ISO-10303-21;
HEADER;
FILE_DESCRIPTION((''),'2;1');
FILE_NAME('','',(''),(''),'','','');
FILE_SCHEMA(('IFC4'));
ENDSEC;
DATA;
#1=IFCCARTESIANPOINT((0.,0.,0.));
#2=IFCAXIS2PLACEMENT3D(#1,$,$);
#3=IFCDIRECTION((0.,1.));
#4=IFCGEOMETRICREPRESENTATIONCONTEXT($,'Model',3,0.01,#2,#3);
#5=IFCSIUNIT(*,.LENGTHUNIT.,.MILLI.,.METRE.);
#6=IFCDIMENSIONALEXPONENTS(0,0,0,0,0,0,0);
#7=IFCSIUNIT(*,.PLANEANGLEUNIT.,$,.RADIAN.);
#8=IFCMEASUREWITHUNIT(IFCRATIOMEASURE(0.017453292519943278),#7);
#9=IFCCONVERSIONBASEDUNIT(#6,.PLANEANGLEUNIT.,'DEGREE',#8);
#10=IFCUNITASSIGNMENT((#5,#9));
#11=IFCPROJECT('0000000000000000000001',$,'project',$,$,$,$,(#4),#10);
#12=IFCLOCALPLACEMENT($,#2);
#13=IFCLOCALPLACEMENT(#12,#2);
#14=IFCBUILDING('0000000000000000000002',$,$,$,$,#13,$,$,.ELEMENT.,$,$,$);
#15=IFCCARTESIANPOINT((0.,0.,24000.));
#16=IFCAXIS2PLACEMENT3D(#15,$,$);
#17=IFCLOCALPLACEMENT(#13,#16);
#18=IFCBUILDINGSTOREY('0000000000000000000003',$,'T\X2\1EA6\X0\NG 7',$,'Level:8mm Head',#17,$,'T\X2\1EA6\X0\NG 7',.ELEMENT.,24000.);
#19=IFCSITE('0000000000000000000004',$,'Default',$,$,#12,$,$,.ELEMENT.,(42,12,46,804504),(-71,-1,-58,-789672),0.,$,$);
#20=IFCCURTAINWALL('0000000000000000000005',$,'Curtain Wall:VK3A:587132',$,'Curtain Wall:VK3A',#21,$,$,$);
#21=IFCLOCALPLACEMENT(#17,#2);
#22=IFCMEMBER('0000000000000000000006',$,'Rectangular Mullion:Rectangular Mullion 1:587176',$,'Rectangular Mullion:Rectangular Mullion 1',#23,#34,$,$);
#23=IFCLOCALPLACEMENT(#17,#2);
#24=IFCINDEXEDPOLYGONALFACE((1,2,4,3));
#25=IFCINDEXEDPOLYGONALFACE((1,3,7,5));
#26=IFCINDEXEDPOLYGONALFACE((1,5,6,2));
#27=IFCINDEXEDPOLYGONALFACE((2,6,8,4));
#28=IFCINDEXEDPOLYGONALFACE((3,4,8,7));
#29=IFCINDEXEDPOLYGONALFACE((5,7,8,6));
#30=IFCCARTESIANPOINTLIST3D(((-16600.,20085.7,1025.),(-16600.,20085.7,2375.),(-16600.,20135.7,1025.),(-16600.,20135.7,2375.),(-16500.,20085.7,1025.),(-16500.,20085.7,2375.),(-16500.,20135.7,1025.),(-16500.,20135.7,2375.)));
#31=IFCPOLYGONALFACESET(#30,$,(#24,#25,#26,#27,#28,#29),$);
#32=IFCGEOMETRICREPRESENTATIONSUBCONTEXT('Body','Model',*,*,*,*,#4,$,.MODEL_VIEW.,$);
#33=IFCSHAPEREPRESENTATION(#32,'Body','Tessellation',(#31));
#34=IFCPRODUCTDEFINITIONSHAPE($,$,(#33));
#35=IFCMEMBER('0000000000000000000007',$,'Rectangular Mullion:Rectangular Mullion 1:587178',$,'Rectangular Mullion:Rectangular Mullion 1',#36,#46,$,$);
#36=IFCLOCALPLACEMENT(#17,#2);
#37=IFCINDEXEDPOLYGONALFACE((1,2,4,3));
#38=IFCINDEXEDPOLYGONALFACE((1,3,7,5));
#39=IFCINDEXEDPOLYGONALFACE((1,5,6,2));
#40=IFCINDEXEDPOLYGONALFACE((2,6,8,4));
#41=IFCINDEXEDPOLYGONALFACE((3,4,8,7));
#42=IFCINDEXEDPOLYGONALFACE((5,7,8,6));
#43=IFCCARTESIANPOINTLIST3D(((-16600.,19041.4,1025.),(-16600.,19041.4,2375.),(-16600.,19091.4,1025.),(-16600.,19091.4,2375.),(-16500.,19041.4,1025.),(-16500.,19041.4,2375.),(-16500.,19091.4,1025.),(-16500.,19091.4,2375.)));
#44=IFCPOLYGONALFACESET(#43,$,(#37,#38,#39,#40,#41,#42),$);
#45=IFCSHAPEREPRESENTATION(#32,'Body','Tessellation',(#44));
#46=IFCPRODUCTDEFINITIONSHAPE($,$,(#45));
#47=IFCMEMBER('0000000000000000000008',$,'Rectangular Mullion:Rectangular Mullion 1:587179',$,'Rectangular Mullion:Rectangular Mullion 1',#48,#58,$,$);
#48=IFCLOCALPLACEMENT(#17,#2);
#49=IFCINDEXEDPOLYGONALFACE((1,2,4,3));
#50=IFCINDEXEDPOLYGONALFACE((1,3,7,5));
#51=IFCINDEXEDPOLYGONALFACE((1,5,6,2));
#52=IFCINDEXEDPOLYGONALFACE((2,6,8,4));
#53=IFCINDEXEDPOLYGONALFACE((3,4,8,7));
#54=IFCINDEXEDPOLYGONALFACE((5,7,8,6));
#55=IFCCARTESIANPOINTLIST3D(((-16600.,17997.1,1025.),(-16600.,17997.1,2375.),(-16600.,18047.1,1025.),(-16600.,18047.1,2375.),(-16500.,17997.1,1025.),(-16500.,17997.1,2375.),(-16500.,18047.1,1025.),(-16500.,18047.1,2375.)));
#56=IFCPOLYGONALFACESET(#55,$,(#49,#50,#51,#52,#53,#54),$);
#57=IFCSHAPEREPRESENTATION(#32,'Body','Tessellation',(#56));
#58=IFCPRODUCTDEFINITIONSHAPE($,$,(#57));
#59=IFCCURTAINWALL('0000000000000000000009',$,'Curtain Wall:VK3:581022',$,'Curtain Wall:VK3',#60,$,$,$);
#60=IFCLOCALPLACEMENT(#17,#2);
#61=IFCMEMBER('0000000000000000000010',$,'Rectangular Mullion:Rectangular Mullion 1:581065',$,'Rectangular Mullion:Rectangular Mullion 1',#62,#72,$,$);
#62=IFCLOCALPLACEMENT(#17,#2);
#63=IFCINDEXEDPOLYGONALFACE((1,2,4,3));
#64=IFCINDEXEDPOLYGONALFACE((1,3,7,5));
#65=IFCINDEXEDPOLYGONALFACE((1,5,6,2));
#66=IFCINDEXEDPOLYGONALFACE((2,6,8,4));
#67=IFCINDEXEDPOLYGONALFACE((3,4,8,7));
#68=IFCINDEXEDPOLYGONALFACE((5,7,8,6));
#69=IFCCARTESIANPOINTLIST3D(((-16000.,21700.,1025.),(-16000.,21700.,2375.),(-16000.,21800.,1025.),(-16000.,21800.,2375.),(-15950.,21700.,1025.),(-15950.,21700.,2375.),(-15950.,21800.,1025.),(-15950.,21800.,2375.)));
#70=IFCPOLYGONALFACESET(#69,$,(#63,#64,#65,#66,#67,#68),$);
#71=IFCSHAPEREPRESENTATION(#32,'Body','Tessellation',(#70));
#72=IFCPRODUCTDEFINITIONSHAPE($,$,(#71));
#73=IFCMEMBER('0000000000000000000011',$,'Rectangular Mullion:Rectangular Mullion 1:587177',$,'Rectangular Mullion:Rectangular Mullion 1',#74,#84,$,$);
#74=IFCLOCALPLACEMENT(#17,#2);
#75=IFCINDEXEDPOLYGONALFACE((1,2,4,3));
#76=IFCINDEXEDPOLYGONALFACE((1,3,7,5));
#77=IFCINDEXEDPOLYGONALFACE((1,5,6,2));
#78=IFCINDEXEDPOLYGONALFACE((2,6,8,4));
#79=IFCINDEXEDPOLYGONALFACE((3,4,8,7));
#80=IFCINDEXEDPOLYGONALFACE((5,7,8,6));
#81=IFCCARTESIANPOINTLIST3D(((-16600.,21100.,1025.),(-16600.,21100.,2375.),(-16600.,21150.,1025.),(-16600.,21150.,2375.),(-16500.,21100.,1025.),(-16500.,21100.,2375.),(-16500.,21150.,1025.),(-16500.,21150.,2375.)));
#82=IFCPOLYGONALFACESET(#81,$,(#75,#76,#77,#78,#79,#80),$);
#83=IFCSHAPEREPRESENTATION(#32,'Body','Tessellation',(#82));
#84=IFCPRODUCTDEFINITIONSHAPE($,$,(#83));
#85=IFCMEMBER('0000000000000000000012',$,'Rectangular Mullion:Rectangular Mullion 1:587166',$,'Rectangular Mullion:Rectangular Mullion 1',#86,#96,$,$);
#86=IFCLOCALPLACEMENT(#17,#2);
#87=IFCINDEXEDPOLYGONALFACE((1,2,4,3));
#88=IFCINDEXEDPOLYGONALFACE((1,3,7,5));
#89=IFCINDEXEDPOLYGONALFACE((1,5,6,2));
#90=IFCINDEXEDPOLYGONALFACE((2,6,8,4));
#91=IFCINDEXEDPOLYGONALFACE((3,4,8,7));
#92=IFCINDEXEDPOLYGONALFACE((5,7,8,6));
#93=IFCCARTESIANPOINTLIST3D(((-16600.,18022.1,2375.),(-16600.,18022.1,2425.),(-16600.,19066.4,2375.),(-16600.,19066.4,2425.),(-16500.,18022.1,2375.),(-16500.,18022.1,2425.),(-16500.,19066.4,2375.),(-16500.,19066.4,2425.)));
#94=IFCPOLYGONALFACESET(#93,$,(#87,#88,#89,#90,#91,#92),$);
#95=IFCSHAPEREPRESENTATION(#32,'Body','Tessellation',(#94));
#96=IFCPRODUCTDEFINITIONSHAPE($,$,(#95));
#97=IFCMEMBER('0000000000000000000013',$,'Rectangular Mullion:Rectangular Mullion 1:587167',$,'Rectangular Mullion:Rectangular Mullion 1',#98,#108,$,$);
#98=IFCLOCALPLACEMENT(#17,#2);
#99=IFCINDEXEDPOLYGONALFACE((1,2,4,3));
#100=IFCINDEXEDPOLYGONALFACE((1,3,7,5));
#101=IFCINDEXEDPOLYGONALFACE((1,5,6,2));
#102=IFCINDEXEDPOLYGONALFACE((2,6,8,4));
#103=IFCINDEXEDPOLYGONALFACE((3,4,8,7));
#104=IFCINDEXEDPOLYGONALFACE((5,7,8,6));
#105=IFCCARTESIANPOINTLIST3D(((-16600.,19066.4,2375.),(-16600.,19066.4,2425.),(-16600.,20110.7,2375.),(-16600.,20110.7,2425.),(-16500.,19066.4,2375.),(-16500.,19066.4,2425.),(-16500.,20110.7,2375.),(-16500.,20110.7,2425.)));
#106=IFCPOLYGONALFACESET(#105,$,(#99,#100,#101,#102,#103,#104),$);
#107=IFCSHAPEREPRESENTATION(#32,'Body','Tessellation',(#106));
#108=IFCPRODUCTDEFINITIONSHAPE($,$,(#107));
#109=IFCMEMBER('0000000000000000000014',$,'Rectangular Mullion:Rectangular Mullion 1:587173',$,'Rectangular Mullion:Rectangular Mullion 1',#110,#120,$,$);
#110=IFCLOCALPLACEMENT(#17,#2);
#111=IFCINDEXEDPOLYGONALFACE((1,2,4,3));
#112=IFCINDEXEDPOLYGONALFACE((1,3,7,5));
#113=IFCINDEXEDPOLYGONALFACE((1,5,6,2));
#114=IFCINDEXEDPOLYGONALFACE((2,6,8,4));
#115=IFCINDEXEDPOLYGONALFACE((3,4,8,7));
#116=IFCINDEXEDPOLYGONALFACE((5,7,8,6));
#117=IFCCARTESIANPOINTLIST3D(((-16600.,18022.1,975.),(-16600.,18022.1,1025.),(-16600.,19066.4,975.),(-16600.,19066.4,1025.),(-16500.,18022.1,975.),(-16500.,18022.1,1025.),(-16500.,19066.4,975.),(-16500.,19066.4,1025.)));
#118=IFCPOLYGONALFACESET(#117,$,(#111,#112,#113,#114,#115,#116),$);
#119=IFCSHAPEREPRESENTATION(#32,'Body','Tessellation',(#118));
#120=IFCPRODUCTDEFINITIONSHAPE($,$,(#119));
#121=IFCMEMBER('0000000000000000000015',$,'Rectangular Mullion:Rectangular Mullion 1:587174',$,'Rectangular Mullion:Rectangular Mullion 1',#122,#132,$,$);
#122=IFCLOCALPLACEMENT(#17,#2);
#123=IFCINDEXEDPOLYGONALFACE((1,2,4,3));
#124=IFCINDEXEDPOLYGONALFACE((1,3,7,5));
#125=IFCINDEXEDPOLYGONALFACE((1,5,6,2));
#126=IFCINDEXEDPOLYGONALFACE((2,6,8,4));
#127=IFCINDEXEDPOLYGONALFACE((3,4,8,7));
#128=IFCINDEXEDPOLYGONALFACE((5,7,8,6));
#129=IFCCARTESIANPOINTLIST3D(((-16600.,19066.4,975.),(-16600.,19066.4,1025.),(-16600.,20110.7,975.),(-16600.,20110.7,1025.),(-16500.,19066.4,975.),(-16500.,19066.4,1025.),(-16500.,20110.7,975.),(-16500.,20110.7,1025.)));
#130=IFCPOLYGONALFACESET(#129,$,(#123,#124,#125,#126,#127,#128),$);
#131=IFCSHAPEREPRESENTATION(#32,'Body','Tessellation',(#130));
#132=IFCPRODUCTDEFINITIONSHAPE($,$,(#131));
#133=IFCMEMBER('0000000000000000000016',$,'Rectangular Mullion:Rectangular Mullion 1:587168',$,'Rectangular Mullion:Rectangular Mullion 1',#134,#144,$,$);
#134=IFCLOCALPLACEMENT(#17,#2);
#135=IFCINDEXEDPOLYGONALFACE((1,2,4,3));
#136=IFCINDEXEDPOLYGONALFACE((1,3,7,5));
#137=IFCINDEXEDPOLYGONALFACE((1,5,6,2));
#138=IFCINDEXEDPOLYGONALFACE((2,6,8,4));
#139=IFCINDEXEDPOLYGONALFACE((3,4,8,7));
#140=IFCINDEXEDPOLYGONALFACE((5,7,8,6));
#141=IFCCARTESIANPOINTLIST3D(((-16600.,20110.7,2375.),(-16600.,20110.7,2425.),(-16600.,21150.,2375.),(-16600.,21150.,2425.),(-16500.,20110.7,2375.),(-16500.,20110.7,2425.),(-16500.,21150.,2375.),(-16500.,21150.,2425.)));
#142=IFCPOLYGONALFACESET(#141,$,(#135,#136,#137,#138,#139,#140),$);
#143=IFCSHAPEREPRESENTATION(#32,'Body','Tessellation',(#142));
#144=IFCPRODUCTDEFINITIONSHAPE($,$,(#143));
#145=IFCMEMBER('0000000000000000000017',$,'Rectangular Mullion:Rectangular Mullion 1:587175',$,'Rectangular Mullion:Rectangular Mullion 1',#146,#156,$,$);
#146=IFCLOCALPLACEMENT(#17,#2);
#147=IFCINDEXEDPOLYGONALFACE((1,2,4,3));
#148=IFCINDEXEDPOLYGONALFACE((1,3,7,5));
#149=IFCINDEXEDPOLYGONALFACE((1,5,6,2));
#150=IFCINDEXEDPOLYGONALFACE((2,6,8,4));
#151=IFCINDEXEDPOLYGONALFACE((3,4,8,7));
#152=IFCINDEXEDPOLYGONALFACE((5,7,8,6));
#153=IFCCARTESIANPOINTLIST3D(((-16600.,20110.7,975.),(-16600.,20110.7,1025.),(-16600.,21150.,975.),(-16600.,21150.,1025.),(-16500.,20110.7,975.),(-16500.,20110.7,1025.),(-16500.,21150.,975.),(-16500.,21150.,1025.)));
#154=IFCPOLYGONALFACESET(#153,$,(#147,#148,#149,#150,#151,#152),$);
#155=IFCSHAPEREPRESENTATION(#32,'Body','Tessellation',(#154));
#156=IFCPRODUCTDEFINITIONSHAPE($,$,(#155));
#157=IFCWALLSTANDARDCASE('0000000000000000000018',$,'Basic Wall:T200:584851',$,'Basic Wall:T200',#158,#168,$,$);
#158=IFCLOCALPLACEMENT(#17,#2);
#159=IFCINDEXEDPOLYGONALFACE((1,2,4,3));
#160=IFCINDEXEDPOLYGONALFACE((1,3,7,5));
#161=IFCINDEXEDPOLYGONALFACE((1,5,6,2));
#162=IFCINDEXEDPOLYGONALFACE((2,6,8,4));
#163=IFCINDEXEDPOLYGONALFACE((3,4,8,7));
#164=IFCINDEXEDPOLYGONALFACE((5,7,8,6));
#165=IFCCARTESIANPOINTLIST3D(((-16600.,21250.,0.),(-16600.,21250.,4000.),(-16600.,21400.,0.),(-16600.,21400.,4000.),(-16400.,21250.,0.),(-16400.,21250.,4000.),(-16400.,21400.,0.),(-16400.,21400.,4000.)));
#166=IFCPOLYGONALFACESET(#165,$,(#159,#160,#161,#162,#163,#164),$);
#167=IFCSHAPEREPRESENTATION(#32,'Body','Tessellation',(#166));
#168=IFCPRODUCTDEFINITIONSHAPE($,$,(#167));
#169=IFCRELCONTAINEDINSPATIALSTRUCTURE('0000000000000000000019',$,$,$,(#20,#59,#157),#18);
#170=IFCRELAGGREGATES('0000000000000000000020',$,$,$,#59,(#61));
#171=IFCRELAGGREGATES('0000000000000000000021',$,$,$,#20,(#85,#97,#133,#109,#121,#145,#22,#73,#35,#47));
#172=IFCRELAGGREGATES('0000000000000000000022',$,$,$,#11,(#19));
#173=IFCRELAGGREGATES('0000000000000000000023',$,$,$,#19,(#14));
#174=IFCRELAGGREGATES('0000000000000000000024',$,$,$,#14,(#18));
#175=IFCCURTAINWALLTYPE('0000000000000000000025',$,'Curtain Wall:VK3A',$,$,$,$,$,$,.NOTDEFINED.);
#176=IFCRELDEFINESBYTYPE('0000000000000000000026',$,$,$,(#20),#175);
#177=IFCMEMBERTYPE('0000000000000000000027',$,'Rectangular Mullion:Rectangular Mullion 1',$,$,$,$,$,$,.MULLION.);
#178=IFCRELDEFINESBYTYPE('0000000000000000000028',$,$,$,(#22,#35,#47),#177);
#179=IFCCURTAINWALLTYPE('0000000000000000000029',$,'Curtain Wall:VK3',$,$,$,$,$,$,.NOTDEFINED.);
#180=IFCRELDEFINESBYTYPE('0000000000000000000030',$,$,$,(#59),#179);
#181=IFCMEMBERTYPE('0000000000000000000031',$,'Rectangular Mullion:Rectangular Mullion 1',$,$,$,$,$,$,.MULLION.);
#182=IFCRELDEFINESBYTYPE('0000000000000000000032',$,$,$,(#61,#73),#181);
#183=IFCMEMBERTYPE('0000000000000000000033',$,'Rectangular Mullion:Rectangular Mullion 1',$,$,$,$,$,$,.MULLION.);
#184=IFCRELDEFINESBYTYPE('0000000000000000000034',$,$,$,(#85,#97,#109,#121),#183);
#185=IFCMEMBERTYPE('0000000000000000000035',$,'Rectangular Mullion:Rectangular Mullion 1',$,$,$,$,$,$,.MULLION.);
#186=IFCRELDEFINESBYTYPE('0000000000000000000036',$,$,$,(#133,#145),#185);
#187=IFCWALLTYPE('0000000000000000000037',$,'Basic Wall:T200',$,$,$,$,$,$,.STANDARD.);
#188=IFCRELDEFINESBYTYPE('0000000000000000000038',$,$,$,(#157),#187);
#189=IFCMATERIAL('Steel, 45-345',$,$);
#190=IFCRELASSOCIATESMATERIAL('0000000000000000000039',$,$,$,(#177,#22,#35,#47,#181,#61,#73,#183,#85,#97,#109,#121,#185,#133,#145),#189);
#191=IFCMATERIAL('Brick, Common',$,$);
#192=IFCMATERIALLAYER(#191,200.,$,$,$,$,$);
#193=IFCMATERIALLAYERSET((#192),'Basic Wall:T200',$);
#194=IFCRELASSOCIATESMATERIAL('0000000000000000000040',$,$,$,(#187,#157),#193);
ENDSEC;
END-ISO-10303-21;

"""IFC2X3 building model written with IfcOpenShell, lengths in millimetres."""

from ifc_helpers import new_model, entity, si_unit, converted_unit, direction, frame, frame_2d, origin, origin_2d_with_axis, place, context, subcontext, project, spatial, rectangle, extrude, source, transform, mapped, material, layer, layer_set, layer_usage, type_object, type_shapes, element, aggregate, save


model = new_model("IFC2X3")

# Units and contexts
model_context = context("Model", 3, precision=0.01, world=origin(), true_north=direction((0.0, 1.0)))
body_context = subcontext(model_context, "Body", "Model", "MODEL_VIEW")
ifc_project = project(units=[si_unit("LENGTHUNIT", "METRE", prefix="MILLI"), converted_unit("PLANEANGLEUNIT", "DEGREE", entity("IfcRatioMeasure", 0.017453292519943278), si_unit("PLANEANGLEUNIT", "RADIAN"), dimensions=[0, 0, 0, 0, 0, 0, 0])], contexts=[model_context])

# Site, building, storey
site_placement = place(None, origin())
site = spatial("IfcSite", under=ifc_project, at=site_placement, Name="Default", CompositionType="ELEMENT", RefLatitude=(42, 12, 46, 804504), RefLongitude=(-71, -1, -58, -789672), RefElevation=0.0)
building_placement = place(site_placement, origin())
building = spatial("IfcBuilding", under=site, at=building_placement, CompositionType="ELEMENT")
storey_placement = place(building_placement, frame((0.0, 0.0, 24000.0)))
storey = spatial("IfcBuildingStorey", under=building, at=storey_placement, Name="TẦNG 7", ObjectType="Level:8mm Head", LongName="TẦNG 7", CompositionType="ELEMENT", Elevation=24000.0)

# Curtain wall, members
curtain_wall_type_1 = type_object("IfcCurtainWallType", Name="Curtain Wall:VK3A", PredefinedType="NOTDEFINED")
curtain_wall_1_placement = place(storey_placement, frame((0.0, 0.0, -24000.0)))
curtain_wall_1 = element("IfcCurtainWall", 1, at=curtain_wall_1_placement, inside=storey, type_object=curtain_wall_type_1, Name="Curtain Wall:VK3A:587132", ObjectType="Curtain Wall:VK3A")
ifc_material_1 = material(Name="Steel, 45-345")
member_type_1 = type_object("IfcMemberType", Name="Rectangular Mullion:Rectangular Mullion 1", PredefinedType="MULLION", material=ifc_material_1)
shared_shape_1 = source(origin(), body_context, "Body", "SweptSolid", [
    extrude(rectangle(XDim=100.0, YDim=50.0, at=origin_2d_with_axis()), frame((0.0, -50.0, -1350.0), z_axis=(0.0, 0.0, 1.0), x_axis=(0.0, -1.0, 0.0)), (0.0, 0.0, 1.0), 1350.0),
])
type_shapes(member_type_1, [shared_shape_1])
member_1_placement = place(curtain_wall_1_placement, frame((-16600.0, 20110.7, 25025.0), z_axis=(0.0, 0.0, -1.0), x_axis=(0.0, -1.0, 0.0)))
member_1 = element("IfcMember", 2, at=member_1_placement, type_object=member_type_1, material=ifc_material_1, Name="Rectangular Mullion:Rectangular Mullion 1:587176", ObjectType="Rectangular Mullion:Rectangular Mullion 1", context=body_context, shape_type="MappedRepresentation", body=[
    mapped(shared_shape_1, transform((0.0, 0.0, 0.0), scale=1.0)),
])
member_2_placement = place(curtain_wall_1_placement, frame((-16600.0, 19066.4, 25025.0), z_axis=(0.0, 0.0, -1.0), x_axis=(0.0, -1.0, 0.0)))
member_2 = element("IfcMember", 3, at=member_2_placement, type_object=member_type_1, material=ifc_material_1, Name="Rectangular Mullion:Rectangular Mullion 1:587178", ObjectType="Rectangular Mullion:Rectangular Mullion 1", context=body_context, shape_type="MappedRepresentation", body=[
    mapped(shared_shape_1, transform((0.0, 0.0, 0.0), scale=1.0)),
])
member_3_placement = place(curtain_wall_1_placement, frame((-16600.0, 18022.1, 25025.0), z_axis=(0.0, 0.0, -1.0), x_axis=(0.0, -1.0, 0.0)))
member_3 = element("IfcMember", 4, at=member_3_placement, type_object=member_type_1, material=ifc_material_1, Name="Rectangular Mullion:Rectangular Mullion 1:587179", ObjectType="Rectangular Mullion:Rectangular Mullion 1", context=body_context, shape_type="MappedRepresentation", body=[
    mapped(shared_shape_1, transform((0.0, 0.0, 0.0), scale=1.0)),
])

# Curtain wall, member
curtain_wall_type_2 = type_object("IfcCurtainWallType", Name="Curtain Wall:VK3", PredefinedType="NOTDEFINED")
curtain_wall_2_placement = place(storey_placement, frame((0.0, 0.0, -24000.0)))
curtain_wall_2 = element("IfcCurtainWall", 5, at=curtain_wall_2_placement, inside=storey, type_object=curtain_wall_type_2, Name="Curtain Wall:VK3:581022", ObjectType="Curtain Wall:VK3")
member_type_2 = type_object("IfcMemberType", Name="Rectangular Mullion:Rectangular Mullion 1", PredefinedType="MULLION", material=ifc_material_1)
shared_shape_2 = source(origin(), body_context, "Body", "SweptSolid", [
    extrude(rectangle(XDim=100.0, YDim=50.0, at=origin_2d_with_axis()), frame((-25.0, -50.0, -1350.0), z_axis=(0.0, 0.0, 1.0), x_axis=(0.0, -1.0, 0.0)), (0.0, 0.0, 1.0), 1350.0),
])
type_shapes(member_type_2, [shared_shape_2])
member_4_placement = place(curtain_wall_2_placement, frame((-16000.0, 21700.0, 26375.0), z_axis=(0.0, 0.0, 1.0), x_axis=(-1.0, 0.0, 0.0)))
member_4 = element("IfcMember", 6, at=member_4_placement, type_object=member_type_2, material=ifc_material_1, Name="Rectangular Mullion:Rectangular Mullion 1:581065", ObjectType="Rectangular Mullion:Rectangular Mullion 1", context=body_context, shape_type="MappedRepresentation", body=[
    mapped(shared_shape_2, transform((0.0, 0.0, 0.0), scale=1.0)),
])
aggregate(curtain_wall_2, [member_4])

# Members
member_5_placement = place(curtain_wall_1_placement, frame((-16600.0, 21150.0, 26375.0), z_axis=(0.0, 0.0, 1.0), x_axis=(0.0, 1.0, 0.0)))
member_5 = element("IfcMember", 7, at=member_5_placement, type_object=member_type_2, material=ifc_material_1, Name="Rectangular Mullion:Rectangular Mullion 1:587177", ObjectType="Rectangular Mullion:Rectangular Mullion 1", context=body_context, shape_type="MappedRepresentation", body=[
    mapped(shared_shape_2, transform((0.0, 0.0, 0.0), scale=1.0)),
])
member_type_3 = type_object("IfcMemberType", Name="Rectangular Mullion:Rectangular Mullion 1", PredefinedType="MULLION", material=ifc_material_1)
shared_shape_3 = source(origin(), body_context, "Body", "SweptSolid", [
    extrude(rectangle(XDim=100.0, YDim=50.0, at=origin_2d_with_axis()), frame((0.0, -50.0, -1044.3), z_axis=(0.0, 0.0, 1.0), x_axis=(0.0, -1.0, 0.0)), (0.0, 0.0, 1.0), 1044.3),
])
type_shapes(member_type_3, [shared_shape_3])
member_6_placement = place(curtain_wall_1_placement, frame((-16600.0, 18022.1, 26400.0), z_axis=(0.0, -1.0, 0.0), x_axis=(0.0, 0.0, 1.0)))
member_6 = element("IfcMember", 8, at=member_6_placement, type_object=member_type_3, material=ifc_material_1, Name="Rectangular Mullion:Rectangular Mullion 1:587166", ObjectType="Rectangular Mullion:Rectangular Mullion 1", context=body_context, shape_type="MappedRepresentation", body=[
    mapped(shared_shape_3, transform((0.0, 0.0, 0.0), scale=1.0)),
])
member_7_placement = place(curtain_wall_1_placement, frame((-16600.0, 19066.4, 26400.0), z_axis=(0.0, -1.0, 0.0), x_axis=(0.0, 0.0, 1.0)))
member_7 = element("IfcMember", 9, at=member_7_placement, type_object=member_type_3, material=ifc_material_1, Name="Rectangular Mullion:Rectangular Mullion 1:587167", ObjectType="Rectangular Mullion:Rectangular Mullion 1", context=body_context, shape_type="MappedRepresentation", body=[
    mapped(shared_shape_3, transform((0.0, 0.0, 0.0), scale=1.0)),
])
member_8_placement = place(curtain_wall_1_placement, frame((-16600.0, 18022.1, 25000.0), z_axis=(0.0, -1.0, 0.0), x_axis=(0.0, 0.0, 1.0)))
member_8 = element("IfcMember", 10, at=member_8_placement, type_object=member_type_3, material=ifc_material_1, Name="Rectangular Mullion:Rectangular Mullion 1:587173", ObjectType="Rectangular Mullion:Rectangular Mullion 1", context=body_context, shape_type="MappedRepresentation", body=[
    mapped(shared_shape_3, transform((0.0, 0.0, 0.0), scale=1.0)),
])
member_9_placement = place(curtain_wall_1_placement, frame((-16600.0, 19066.4, 25000.0), z_axis=(0.0, -1.0, 0.0), x_axis=(0.0, 0.0, 1.0)))
member_9 = element("IfcMember", 11, at=member_9_placement, type_object=member_type_3, material=ifc_material_1, Name="Rectangular Mullion:Rectangular Mullion 1:587174", ObjectType="Rectangular Mullion:Rectangular Mullion 1", context=body_context, shape_type="MappedRepresentation", body=[
    mapped(shared_shape_3, transform((0.0, 0.0, 0.0), scale=1.0)),
])
member_type_4 = type_object("IfcMemberType", Name="Rectangular Mullion:Rectangular Mullion 1", PredefinedType="MULLION", material=ifc_material_1)
shared_shape_4 = source(origin(), body_context, "Body", "SweptSolid", [
    extrude(rectangle(XDim=100.0, YDim=50.0, at=origin_2d_with_axis()), frame((0.0, -50.0, -1039.3), z_axis=(0.0, 0.0, 1.0), x_axis=(0.0, -1.0, 0.0)), (0.0, 0.0, 1.0), 1039.3),
])
type_shapes(member_type_4, [shared_shape_4])
member_10_placement = place(curtain_wall_1_placement, frame((-16600.0, 20110.7, 26400.0), z_axis=(0.0, -1.0, 0.0), x_axis=(0.0, 0.0, 1.0)))
member_10 = element("IfcMember", 12, at=member_10_placement, type_object=member_type_4, material=ifc_material_1, Name="Rectangular Mullion:Rectangular Mullion 1:587168", ObjectType="Rectangular Mullion:Rectangular Mullion 1", context=body_context, shape_type="MappedRepresentation", body=[
    mapped(shared_shape_4, transform((0.0, 0.0, 0.0), scale=1.0)),
])
member_11_placement = place(curtain_wall_1_placement, frame((-16600.0, 20110.7, 25000.0), z_axis=(0.0, -1.0, 0.0), x_axis=(0.0, 0.0, 1.0)))
member_11 = element("IfcMember", 13, at=member_11_placement, type_object=member_type_4, material=ifc_material_1, Name="Rectangular Mullion:Rectangular Mullion 1:587175", ObjectType="Rectangular Mullion:Rectangular Mullion 1", context=body_context, shape_type="MappedRepresentation", body=[
    mapped(shared_shape_4, transform((0.0, 0.0, 0.0), scale=1.0)),
])

aggregate(curtain_wall_1, [member_6, member_7, member_10, member_8, member_9, member_11, member_1, member_5, member_2, member_3])

# Wall
ifc_material_2 = material(Name="Brick, Common")
ifc_layer_1 = layer(ifc_material_2, 200.0)
ifc_layer_set_1 = layer_set([ifc_layer_1], Name="Basic Wall:T200")
ifc_layer_usage_1 = layer_usage(ifc_layer_set_1, "AXIS2", "POSITIVE", -100.0)
wall_type_1 = type_object("IfcWallType", Name="Basic Wall:T200", PredefinedType="STANDARD", material=ifc_layer_set_1)
wall_1_placement = place(storey_placement, frame((-16500.0, 21250.0, 0.0), z_axis=(0.0, 0.0, 1.0), x_axis=(0.0, 1.0, 0.0)))
element("IfcWallStandardCase", 14, at=wall_1_placement, inside=storey, type_object=wall_type_1, material=ifc_layer_usage_1, Name="Basic Wall:T200:584851", ObjectType="Basic Wall:T200", context=body_context, shape_type="SweptSolid", body=[
    extrude(rectangle(XDim=150.0, YDim=200.0, at=frame_2d((75.0, 0.0), x_axis=(-1.0, 0.0))), origin(), (0.0, 0.0, 1.0), 4000.0),
])

save(model, "model.ifc")
